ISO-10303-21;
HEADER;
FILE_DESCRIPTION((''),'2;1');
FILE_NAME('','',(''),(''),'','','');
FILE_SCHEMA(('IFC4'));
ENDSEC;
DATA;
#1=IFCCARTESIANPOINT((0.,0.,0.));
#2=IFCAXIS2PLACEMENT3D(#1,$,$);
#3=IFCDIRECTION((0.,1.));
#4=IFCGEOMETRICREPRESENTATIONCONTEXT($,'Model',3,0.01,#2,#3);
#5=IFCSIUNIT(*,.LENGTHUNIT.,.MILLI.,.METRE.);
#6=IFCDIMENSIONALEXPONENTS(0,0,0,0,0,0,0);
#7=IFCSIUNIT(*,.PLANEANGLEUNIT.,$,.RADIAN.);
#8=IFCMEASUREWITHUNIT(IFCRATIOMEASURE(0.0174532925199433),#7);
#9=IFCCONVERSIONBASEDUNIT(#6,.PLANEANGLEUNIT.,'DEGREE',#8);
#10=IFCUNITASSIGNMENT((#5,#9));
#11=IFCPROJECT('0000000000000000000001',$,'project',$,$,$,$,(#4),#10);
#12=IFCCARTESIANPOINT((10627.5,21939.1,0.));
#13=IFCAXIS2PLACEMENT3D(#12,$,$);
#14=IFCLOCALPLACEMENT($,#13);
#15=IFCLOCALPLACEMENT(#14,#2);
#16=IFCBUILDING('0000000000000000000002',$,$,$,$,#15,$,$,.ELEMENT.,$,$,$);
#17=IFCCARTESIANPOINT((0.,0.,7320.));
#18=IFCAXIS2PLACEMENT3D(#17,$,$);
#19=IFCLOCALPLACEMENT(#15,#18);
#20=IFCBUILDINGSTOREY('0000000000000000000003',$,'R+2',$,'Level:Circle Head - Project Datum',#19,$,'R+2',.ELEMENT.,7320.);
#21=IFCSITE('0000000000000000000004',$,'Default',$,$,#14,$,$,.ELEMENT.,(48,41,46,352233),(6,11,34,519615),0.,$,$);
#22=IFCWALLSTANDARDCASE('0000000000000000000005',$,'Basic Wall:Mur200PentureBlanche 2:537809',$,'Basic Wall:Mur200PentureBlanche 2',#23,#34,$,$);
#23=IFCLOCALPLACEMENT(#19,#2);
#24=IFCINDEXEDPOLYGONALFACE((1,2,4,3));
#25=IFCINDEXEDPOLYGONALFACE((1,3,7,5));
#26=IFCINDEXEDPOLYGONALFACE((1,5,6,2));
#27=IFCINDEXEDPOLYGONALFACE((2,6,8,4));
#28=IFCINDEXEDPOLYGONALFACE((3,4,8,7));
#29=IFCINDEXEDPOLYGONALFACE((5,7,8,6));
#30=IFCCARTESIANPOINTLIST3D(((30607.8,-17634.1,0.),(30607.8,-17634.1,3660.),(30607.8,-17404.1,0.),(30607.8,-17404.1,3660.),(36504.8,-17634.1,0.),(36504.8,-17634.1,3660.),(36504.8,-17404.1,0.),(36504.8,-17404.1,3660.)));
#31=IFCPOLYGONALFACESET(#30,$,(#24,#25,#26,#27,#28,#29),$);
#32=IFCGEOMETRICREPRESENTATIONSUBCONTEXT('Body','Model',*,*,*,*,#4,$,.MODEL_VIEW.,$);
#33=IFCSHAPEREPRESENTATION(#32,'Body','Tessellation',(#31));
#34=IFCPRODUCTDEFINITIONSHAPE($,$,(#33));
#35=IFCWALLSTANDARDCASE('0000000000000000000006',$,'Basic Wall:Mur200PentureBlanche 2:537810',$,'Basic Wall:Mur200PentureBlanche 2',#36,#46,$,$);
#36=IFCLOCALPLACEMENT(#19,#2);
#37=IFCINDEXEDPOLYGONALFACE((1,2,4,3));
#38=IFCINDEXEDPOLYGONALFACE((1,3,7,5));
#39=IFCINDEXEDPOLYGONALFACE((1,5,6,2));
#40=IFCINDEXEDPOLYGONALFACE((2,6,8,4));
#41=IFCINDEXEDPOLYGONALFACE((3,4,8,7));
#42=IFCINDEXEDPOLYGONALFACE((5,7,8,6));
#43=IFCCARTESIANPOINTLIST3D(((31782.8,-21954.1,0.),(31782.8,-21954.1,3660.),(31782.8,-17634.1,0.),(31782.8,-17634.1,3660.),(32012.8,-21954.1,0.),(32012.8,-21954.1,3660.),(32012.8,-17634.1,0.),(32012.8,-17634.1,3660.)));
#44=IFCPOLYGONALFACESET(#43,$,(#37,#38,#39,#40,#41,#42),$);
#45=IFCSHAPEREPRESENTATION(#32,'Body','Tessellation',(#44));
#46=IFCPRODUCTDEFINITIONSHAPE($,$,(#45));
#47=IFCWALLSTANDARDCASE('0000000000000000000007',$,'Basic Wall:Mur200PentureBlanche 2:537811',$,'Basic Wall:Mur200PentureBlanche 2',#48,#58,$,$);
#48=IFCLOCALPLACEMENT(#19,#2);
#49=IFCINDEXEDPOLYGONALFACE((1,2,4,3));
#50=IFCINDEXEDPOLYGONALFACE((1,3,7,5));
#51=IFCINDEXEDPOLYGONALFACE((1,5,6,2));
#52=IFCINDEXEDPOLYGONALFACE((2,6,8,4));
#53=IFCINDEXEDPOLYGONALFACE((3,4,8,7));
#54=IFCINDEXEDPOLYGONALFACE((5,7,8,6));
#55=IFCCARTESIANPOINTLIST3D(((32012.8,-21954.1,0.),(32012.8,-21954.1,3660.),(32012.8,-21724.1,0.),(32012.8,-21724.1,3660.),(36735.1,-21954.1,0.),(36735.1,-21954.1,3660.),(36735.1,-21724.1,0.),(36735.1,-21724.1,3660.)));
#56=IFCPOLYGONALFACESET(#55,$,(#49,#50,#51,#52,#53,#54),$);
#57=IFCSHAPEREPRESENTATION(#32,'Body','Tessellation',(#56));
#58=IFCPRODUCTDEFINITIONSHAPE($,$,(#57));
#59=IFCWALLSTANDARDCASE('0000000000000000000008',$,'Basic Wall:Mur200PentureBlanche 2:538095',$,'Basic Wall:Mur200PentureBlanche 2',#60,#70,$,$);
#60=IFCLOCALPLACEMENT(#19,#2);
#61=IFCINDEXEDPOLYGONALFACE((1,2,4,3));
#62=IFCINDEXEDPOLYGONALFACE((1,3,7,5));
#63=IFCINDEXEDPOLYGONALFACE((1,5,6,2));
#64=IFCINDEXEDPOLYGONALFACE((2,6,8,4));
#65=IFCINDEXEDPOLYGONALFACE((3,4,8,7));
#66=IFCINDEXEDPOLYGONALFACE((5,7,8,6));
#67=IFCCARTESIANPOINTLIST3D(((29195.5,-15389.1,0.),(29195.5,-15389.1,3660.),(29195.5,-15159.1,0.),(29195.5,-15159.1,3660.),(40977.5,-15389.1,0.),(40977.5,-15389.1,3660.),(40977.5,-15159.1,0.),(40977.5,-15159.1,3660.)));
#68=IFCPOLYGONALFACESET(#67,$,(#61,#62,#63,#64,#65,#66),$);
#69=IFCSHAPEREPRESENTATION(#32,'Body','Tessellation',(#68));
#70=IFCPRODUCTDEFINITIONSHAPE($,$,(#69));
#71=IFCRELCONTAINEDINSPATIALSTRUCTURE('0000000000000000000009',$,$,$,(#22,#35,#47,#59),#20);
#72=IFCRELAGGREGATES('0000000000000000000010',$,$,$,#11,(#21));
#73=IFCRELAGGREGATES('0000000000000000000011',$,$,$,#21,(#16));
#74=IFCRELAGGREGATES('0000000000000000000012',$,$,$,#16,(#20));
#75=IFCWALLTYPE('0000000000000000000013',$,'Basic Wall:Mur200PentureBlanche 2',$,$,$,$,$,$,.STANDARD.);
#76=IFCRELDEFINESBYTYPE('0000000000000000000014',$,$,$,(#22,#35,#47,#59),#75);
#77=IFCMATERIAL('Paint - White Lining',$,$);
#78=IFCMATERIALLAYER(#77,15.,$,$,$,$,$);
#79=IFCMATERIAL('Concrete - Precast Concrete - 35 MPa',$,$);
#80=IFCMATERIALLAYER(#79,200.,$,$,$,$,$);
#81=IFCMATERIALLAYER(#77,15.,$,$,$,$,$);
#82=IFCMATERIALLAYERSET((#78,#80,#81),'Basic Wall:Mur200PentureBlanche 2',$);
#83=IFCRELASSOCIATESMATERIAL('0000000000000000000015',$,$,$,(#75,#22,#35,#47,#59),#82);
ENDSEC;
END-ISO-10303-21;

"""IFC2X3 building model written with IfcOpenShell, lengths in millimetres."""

from ifc_helpers import new_model, entity, si_unit, converted_unit, direction, frame, frame_2d, origin, place, context, subcontext, project, spatial, rectangle, extrude, material, layer, layer_set, layer_usage, type_object, element, save


model = new_model("IFC2X3")

# Units and contexts
model_context = context("Model", 3, precision=0.01, world=origin(), true_north=direction((0.0, 1.0)))
body_context = subcontext(model_context, "Body", "Model", "MODEL_VIEW")
ifc_project = project(units=[si_unit("LENGTHUNIT", "METRE", prefix="MILLI"), converted_unit("PLANEANGLEUNIT", "DEGREE", entity("IfcRatioMeasure", 0.0174532925199433), si_unit("PLANEANGLEUNIT", "RADIAN"), dimensions=[0, 0, 0, 0, 0, 0, 0])], contexts=[model_context])

# Site, building, storey
site_placement = place(None, frame((10627.5, 21939.1, 0.0)))
site = spatial("IfcSite", under=ifc_project, at=site_placement, Name="Default", CompositionType="ELEMENT", RefLatitude=(48, 41, 46, 352233), RefLongitude=(6, 11, 34, 519615), RefElevation=0.0)
building_placement = place(site_placement, origin())
building = spatial("IfcBuilding", under=site, at=building_placement, CompositionType="ELEMENT")
storey_placement = place(building_placement, frame((0.0, 0.0, 7320.0)))
storey = spatial("IfcBuildingStorey", under=building, at=storey_placement, Name="R+2", ObjectType="Level:Circle Head - Project Datum", LongName="R+2", CompositionType="ELEMENT", Elevation=7320.0)

# Walls
ifc_material_1 = material(Name="Paint - White Lining")
ifc_layer_1 = layer(ifc_material_1, 15.0)
ifc_material_2 = material(Name="Concrete - Precast Concrete - 35 MPa")
ifc_layer_2 = layer(ifc_material_2, 200.0)
ifc_layer_3 = layer(ifc_material_1, 15.0)
ifc_layer_set_1 = layer_set([ifc_layer_1, ifc_layer_2, ifc_layer_3], Name="Basic Wall:Mur200PentureBlanche 2")
wall_type_1 = type_object("IfcWallType", Name="Basic Wall:Mur200PentureBlanche 2", PredefinedType="STANDARD", material=ifc_layer_set_1)
ifc_layer_usage_1 = layer_usage(ifc_layer_set_1, "AXIS2", "NEGATIVE", 115.0)
wall_1_placement = place(storey_placement, frame((30607.8, -17519.1, 0.0)))
element("IfcWallStandardCase", 1, at=wall_1_placement, inside=storey, type_object=wall_type_1, material=ifc_layer_usage_1, Name="Basic Wall:Mur200PentureBlanche 2:537809", ObjectType="Basic Wall:Mur200PentureBlanche 2", context=body_context, shape_type="SweptSolid", body=[
    extrude(rectangle(XDim=5897.0, YDim=230.0, at=frame_2d((2948.5, 0.0), x_axis=(-1.0, 0.0))), origin(), (0.0, 0.0, 1.0), 3660.0),
])
ifc_layer_usage_2 = layer_usage(ifc_layer_set_1, "AXIS2", "POSITIVE", -115.0)
wall_2_placement = place(storey_placement, frame((31897.8, -17634.1, 0.0), z_axis=(0.0, 0.0, 1.0), x_axis=(0.0, -1.0, 0.0)))
element("IfcWallStandardCase", 2, at=wall_2_placement, inside=storey, type_object=wall_type_1, material=ifc_layer_usage_2, Name="Basic Wall:Mur200PentureBlanche 2:537810", ObjectType="Basic Wall:Mur200PentureBlanche 2", context=body_context, shape_type="SweptSolid", body=[
    extrude(rectangle(XDim=4320.0, YDim=230.0, at=frame_2d((2160.0, 0.0), x_axis=(-1.0, 0.0))), origin(), (0.0, 0.0, 1.0), 3660.0),
])
ifc_layer_usage_3 = layer_usage(ifc_layer_set_1, "AXIS2", "POSITIVE", -115.0)
wall_3_placement = place(storey_placement, frame((32012.8, -21839.1, 0.0)))
element("IfcWallStandardCase", 3, at=wall_3_placement, inside=storey, type_object=wall_type_1, material=ifc_layer_usage_3, Name="Basic Wall:Mur200PentureBlanche 2:537811", ObjectType="Basic Wall:Mur200PentureBlanche 2", context=body_context, shape_type="SweptSolid", body=[
    extrude(rectangle(XDim=4722.3, YDim=230.0, at=frame_2d((2361.1, 0.0), x_axis=(-1.0, 0.0))), origin(), (0.0, 0.0, 1.0), 3660.0),
])
ifc_layer_usage_4 = layer_usage(ifc_layer_set_1, "AXIS2", "NEGATIVE", 115.0)
wall_4_placement = place(storey_placement, frame((40977.5, -15274.1, 0.0), z_axis=(0.0, 0.0, 1.0), x_axis=(-1.0, 0.0, 0.0)))
element("IfcWallStandardCase", 4, at=wall_4_placement, inside=storey, type_object=wall_type_1, material=ifc_layer_usage_4, Name="Basic Wall:Mur200PentureBlanche 2:538095", ObjectType="Basic Wall:Mur200PentureBlanche 2", context=body_context, shape_type="SweptSolid", body=[
    extrude(rectangle(XDim=11782.0, YDim=230.0, at=frame_2d((5891.0, 0.0), x_axis=(-1.0, 0.0))), origin(), (0.0, 0.0, 1.0), 3660.0),
])

save(model, "model.ifc")
